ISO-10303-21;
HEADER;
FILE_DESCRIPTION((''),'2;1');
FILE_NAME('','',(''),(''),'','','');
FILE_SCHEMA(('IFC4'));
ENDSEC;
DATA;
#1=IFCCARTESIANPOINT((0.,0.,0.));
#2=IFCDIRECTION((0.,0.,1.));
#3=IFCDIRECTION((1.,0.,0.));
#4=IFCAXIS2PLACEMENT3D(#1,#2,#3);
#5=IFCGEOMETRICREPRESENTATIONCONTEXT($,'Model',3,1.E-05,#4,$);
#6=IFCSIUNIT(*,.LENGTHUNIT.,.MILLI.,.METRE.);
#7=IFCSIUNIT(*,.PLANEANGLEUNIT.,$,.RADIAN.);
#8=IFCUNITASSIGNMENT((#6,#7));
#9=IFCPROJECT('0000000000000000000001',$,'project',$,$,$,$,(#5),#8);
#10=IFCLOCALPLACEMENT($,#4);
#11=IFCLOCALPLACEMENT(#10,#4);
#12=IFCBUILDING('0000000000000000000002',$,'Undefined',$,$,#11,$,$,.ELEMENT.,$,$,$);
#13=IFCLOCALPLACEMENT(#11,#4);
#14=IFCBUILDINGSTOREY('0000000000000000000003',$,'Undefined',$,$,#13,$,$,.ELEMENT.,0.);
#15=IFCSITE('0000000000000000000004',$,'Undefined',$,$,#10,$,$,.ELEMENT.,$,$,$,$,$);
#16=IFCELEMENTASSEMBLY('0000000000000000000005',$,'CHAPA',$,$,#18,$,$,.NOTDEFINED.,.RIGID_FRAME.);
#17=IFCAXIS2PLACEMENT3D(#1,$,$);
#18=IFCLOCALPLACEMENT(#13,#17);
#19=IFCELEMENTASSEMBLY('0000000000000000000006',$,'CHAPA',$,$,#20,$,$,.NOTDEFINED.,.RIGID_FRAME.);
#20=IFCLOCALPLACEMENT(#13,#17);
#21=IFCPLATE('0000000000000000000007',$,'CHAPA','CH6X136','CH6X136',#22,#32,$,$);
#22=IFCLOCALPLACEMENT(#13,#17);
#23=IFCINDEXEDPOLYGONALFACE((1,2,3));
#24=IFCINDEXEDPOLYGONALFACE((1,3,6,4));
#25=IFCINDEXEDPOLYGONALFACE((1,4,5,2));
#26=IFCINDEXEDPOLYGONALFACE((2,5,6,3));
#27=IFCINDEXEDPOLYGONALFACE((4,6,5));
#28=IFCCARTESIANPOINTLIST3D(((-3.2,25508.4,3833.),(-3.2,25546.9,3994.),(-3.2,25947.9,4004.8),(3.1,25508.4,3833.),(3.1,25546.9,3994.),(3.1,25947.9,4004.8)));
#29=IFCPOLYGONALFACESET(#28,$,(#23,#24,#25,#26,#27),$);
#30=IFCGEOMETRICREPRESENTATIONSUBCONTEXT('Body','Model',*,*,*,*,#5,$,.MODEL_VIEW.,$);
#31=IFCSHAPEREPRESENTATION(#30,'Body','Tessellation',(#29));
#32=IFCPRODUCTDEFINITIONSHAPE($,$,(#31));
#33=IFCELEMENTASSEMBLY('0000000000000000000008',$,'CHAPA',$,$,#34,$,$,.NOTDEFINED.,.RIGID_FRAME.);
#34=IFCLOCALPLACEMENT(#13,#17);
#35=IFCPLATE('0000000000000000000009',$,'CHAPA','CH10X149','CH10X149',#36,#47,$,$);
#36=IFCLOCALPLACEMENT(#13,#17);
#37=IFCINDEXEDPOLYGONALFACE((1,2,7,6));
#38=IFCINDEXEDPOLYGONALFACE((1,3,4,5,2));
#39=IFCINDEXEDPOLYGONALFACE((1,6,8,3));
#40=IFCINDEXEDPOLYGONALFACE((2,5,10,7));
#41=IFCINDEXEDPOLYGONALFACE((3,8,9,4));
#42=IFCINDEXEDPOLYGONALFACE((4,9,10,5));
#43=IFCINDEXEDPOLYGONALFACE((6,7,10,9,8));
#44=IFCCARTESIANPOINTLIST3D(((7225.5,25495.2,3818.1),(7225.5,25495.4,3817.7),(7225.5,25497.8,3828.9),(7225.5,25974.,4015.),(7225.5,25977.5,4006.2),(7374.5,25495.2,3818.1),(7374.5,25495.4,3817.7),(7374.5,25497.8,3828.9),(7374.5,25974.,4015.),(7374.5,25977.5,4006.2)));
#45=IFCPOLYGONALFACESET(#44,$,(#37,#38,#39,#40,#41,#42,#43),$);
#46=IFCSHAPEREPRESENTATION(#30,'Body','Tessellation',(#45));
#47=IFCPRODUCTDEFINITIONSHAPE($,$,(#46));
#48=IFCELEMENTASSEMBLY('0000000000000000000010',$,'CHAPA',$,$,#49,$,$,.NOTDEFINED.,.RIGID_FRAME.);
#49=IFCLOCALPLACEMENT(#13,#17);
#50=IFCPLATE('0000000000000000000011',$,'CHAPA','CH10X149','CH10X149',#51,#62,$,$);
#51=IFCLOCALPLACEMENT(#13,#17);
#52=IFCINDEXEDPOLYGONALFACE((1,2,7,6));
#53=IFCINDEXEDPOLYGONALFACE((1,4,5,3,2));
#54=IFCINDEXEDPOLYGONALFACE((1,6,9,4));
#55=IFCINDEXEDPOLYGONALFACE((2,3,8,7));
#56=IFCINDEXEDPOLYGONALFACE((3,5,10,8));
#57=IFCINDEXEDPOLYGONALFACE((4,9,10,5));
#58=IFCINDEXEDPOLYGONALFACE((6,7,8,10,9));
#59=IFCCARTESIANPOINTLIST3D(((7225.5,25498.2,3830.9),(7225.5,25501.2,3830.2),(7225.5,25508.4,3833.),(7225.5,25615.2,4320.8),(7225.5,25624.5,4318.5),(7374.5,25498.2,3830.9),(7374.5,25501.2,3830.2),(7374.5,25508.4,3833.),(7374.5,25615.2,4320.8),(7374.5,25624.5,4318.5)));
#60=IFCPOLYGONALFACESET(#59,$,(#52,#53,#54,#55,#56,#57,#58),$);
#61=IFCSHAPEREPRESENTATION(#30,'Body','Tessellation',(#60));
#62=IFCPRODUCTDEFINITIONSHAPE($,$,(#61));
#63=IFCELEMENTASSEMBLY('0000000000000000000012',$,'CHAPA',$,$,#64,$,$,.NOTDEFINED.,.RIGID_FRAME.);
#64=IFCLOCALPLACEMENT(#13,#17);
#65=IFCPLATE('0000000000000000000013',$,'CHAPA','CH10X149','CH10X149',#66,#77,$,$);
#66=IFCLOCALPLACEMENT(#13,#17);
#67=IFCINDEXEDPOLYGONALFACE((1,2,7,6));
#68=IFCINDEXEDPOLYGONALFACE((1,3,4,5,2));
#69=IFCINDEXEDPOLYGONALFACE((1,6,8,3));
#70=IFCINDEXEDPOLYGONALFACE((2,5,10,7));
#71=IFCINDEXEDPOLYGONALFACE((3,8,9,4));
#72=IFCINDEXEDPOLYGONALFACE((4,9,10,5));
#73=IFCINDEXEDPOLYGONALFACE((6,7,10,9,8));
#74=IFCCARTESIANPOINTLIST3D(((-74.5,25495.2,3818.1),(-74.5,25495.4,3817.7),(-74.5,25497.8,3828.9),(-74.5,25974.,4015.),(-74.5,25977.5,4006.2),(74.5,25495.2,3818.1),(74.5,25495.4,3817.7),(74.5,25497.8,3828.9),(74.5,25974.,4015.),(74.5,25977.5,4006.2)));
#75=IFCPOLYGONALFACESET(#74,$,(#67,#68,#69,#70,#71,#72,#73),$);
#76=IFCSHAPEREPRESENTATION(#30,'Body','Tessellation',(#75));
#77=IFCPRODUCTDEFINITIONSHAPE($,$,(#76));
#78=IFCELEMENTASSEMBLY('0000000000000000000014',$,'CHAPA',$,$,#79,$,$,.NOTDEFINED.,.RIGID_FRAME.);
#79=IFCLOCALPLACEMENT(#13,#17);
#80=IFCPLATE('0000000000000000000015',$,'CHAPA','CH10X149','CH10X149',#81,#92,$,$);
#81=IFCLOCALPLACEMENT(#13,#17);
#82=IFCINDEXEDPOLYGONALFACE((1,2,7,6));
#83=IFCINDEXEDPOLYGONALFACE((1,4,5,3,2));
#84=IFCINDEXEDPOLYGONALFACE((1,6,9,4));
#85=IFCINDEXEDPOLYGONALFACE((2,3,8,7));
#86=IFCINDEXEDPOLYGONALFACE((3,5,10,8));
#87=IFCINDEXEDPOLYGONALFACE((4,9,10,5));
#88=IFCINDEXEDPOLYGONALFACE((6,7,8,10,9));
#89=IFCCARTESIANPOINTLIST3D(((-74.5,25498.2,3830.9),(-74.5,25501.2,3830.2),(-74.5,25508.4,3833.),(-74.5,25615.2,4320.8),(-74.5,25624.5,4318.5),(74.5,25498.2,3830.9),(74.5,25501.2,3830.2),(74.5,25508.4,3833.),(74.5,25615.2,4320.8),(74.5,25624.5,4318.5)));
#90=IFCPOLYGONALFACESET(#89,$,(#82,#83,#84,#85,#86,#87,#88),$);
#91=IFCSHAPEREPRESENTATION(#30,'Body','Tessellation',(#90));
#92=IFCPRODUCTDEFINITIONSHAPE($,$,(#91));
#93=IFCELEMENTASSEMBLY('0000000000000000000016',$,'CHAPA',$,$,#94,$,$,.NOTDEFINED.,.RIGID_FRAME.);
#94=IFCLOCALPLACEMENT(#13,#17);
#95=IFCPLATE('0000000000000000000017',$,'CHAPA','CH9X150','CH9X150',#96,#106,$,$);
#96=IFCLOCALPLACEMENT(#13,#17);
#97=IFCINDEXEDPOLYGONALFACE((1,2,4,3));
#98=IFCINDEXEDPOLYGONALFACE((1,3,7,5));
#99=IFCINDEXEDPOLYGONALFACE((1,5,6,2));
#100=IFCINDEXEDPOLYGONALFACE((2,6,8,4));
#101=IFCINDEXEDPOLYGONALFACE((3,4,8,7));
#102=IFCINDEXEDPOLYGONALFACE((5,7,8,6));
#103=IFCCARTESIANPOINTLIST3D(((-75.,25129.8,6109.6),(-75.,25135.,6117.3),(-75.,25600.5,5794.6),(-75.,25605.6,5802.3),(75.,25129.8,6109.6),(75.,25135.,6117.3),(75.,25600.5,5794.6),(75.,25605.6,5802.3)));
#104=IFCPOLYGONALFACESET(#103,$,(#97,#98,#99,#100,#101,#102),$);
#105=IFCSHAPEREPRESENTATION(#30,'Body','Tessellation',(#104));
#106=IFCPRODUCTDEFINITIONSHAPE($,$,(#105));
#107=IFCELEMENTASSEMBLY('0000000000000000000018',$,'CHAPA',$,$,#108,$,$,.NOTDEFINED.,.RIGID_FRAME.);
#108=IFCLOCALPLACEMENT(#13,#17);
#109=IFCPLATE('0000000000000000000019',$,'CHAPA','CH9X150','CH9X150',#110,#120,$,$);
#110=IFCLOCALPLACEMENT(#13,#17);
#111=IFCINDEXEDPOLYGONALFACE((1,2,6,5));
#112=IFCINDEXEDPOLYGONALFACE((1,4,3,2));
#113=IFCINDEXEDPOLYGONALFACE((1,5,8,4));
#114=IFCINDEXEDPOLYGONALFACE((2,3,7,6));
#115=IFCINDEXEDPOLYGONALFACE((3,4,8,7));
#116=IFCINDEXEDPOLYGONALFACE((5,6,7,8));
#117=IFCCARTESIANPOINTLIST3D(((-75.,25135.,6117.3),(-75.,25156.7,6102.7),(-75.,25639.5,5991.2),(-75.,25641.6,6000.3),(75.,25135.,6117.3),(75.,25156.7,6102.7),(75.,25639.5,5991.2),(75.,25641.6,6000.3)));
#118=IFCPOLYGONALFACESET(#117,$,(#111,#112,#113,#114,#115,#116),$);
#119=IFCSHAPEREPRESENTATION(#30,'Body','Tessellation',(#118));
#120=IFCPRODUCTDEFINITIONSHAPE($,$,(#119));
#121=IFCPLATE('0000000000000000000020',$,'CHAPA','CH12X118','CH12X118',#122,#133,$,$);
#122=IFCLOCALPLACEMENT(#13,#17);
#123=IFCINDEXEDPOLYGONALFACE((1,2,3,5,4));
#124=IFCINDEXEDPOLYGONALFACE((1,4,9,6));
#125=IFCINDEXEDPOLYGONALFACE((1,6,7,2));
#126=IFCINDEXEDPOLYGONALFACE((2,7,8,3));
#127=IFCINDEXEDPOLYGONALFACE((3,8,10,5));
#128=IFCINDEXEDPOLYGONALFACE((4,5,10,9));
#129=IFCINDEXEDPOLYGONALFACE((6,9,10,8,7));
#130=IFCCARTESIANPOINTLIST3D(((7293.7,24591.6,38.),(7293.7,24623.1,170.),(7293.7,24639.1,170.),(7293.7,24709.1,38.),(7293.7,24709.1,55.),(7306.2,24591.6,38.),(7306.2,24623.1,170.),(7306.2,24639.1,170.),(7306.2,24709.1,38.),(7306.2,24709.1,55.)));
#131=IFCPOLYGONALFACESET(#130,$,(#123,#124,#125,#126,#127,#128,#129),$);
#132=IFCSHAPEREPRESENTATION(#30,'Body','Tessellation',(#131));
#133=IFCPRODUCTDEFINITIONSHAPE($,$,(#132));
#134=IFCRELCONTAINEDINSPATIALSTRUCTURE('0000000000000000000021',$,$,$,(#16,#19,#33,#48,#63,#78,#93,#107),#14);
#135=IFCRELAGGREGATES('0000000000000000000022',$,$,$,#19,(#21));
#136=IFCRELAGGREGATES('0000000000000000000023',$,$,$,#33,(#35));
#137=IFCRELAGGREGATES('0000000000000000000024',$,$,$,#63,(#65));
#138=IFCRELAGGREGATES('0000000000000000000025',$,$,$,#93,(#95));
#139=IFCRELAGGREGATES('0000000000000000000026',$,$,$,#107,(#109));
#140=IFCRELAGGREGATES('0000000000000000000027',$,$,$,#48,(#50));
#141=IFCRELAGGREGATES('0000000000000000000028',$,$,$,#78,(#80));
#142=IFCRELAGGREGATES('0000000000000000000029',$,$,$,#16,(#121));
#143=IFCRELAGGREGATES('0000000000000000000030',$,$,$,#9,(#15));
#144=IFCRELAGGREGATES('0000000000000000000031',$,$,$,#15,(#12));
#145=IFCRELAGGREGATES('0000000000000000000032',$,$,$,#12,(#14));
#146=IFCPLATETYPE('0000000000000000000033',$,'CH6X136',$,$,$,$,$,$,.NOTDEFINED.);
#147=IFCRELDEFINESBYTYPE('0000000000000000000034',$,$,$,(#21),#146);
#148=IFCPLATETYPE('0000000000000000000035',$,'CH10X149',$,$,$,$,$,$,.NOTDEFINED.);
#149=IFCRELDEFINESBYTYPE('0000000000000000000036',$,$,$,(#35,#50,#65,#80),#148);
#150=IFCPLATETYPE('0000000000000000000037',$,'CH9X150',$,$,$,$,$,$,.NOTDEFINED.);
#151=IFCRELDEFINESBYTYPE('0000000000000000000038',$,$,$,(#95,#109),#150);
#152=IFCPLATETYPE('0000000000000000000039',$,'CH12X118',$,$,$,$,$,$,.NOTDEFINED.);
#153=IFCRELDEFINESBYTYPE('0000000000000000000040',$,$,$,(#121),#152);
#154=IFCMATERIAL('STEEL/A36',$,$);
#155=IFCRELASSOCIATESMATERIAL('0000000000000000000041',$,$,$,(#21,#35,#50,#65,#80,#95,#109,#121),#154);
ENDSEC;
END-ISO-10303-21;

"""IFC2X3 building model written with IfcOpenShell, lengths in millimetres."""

from ifc_helpers import new_model, si_unit, frame, origin_with_axes, place, context, subcontext, project, spatial, polyline, outline, extrude, clip, halfspace, material, type_object, element, aggregate, save


model = new_model("IFC2X3")

# Units and contexts
model_context = context("Model", 3, precision=1e-05, world=origin_with_axes())
body_context = subcontext(model_context, "Body", "Model", "MODEL_VIEW")
ifc_project = project(units=[si_unit("LENGTHUNIT", "METRE", prefix="MILLI"), si_unit("PLANEANGLEUNIT", "RADIAN")], contexts=[model_context])

# Site, building, storey
site_placement = place(None, origin_with_axes())
site = spatial("IfcSite", under=ifc_project, at=site_placement, Name="Undefined", CompositionType="ELEMENT")
building_placement = place(site_placement, origin_with_axes())
building = spatial("IfcBuilding", under=site, at=building_placement, Name="Undefined", CompositionType="ELEMENT")
storey_placement = place(building_placement, origin_with_axes())
storey = spatial("IfcBuildingStorey", under=building, at=storey_placement, Name="Undefined", CompositionType="ELEMENT", Elevation=0.0)

# Element assembly
assembly_1_placement = place(storey_placement, origin_with_axes())
assembly_1 = element("IfcElementAssembly", 1, at=assembly_1_placement, inside=storey, Name="CHAPA", AssemblyPlace="NOTDEFINED", PredefinedType="RIGID_FRAME")
ifc_material_1 = material(Name="STEEL/A36")

# Element assemblies, plates
plate_type_1 = type_object("IfcPlateType", Name="CH6X136", PredefinedType="NOTDEFINED")
assembly_2_placement = place(storey_placement, origin_with_axes())
assembly_2 = element("IfcElementAssembly", 2, at=assembly_2_placement, inside=storey, Name="CHAPA", AssemblyPlace="NOTDEFINED", PredefinedType="RIGID_FRAME")
plate_1_placement = place(assembly_2_placement, frame((0.0, 25546.9, 3994.0), z_axis=(-1.0, 0.0, 0.0), x_axis=(0.0, 0.999636, 0.026972)))
plate_1 = element("IfcPlate", 3, at=plate_1_placement, type_object=plate_type_1, material=ifc_material_1, Name="CHAPA", Description="CH6X136", ObjectType="CH6X136", context=body_context, shape_type="SweptSolid", body=[
    extrude(outline(polyline([(0.0, 0.0), (401.1, 0.0), (-42.8, 159.9), (0.0, 0.0)])), frame((0.0, 0.0, -3.1), z_axis=(0.0, 0.0, 1.0), x_axis=(1.0, 0.0, 0.0)), (0.0, 0.0, 1.0), 6.3),
])
aggregate(assembly_2, [plate_1])
assembly_3_placement = place(storey_placement, origin_with_axes())
assembly_3 = element("IfcElementAssembly", 4, at=assembly_3_placement, inside=storey, Name="CHAPA", AssemblyPlace="NOTDEFINED", PredefinedType="RIGID_FRAME")
plate_type_2 = type_object("IfcPlateType", Name="CH10X149", PredefinedType="NOTDEFINED")
plate_2_placement = place(assembly_3_placement, frame((7225.5, 25975.7, 4010.6), z_axis=(0.0, 0.364063, -0.931374), x_axis=(1.0, 0.0, 0.0)))
plate_2 = element("IfcPlate", 5, at=plate_2_placement, type_object=plate_type_2, material=ifc_material_1, Name="CHAPA", Description="CH10X149", ObjectType="CH10X149", context=body_context, shape_type="Clipping", body=[
    clip(extrude(outline(polyline([(0.0, 0.0), (149.0, 0.0), (149.0, 517.6), (0.0, 517.6), (0.0, 0.0)])), frame((0.0, 0.0, -4.8), z_axis=(0.0, 0.0, 1.0), x_axis=(1.0, 0.0, 0.0)), (0.0, 0.0, 1.0), 9.5), halfspace(frame((149.0, 517.9, 4.7), z_axis=(0.0, 0.821204, -0.570634), x_axis=(-1.0, 0.0, 0.0)), False)),
])
aggregate(assembly_3, [plate_2])
assembly_4_placement = place(storey_placement, origin_with_axes())
assembly_4 = element("IfcElementAssembly", 6, at=assembly_4_placement, inside=storey, Name="CHAPA", AssemblyPlace="NOTDEFINED", PredefinedType="RIGID_FRAME")
plate_3_placement = place(assembly_4_placement, frame((7225.5, 25619.9, 4319.6), z_axis=(0.0, 0.972612, -0.232434), x_axis=(1.0, 0.000007, 0.000031)))
plate_3 = element("IfcPlate", 7, at=plate_3_placement, type_object=plate_type_2, material=ifc_material_1, Name="CHAPA", Description="CH10X149", ObjectType="CH10X149", context=body_context, shape_type="Clipping", body=[
    clip(extrude(outline(polyline([(0.0, 0.0), (70.9, 0.0), (149.0, 0.0), (149.0, 503.6), (0.0, 503.6), (0.0, 0.0)])), frame((0.0, 0.0, -4.8), z_axis=(0.0, 0.0, 1.0), x_axis=(1.0, 0.0, 0.0)), (0.0, 0.0, 1.0), 9.5), halfspace(frame((70.9, 499.2, 4.7), z_axis=(-0.000026, 0.821245, 0.570575), x_axis=(-1.0, -0.000032, 0.0)), False)),
])
assembly_5_placement = place(storey_placement, origin_with_axes())
assembly_5 = element("IfcElementAssembly", 8, at=assembly_5_placement, inside=storey, Name="CHAPA", AssemblyPlace="NOTDEFINED", PredefinedType="RIGID_FRAME")
plate_4_placement = place(assembly_5_placement, frame((-74.5, 25975.7, 4010.6), z_axis=(0.0, 0.364063, -0.931374), x_axis=(1.0, 0.0, 0.0)))
plate_4 = element("IfcPlate", 9, at=plate_4_placement, type_object=plate_type_2, material=ifc_material_1, Name="CHAPA", Description="CH10X149", ObjectType="CH10X149", context=body_context, shape_type="Clipping", body=[
    clip(extrude(outline(polyline([(0.0, 0.0), (149.0, 0.0), (149.0, 517.6), (0.0, 517.6), (0.0, 0.0)])), frame((0.0, 0.0, -4.8), z_axis=(0.0, 0.0, 1.0), x_axis=(1.0, 0.0, 0.0)), (0.0, 0.0, 1.0), 9.5), halfspace(frame((149.0, 517.9, 4.7), z_axis=(0.0, 0.821204, -0.570634), x_axis=(-1.0, 0.0, 0.0)), False)),
])
aggregate(assembly_5, [plate_4])
assembly_6_placement = place(storey_placement, origin_with_axes())
assembly_6 = element("IfcElementAssembly", 10, at=assembly_6_placement, inside=storey, Name="CHAPA", AssemblyPlace="NOTDEFINED", PredefinedType="RIGID_FRAME")
plate_5_placement = place(assembly_6_placement, frame((-74.5, 25619.9, 4319.6), z_axis=(0.0, 0.972612, -0.232434), x_axis=(1.0, 0.000007, 0.000031)))
plate_5 = element("IfcPlate", 11, at=plate_5_placement, type_object=plate_type_2, material=ifc_material_1, Name="CHAPA", Description="CH10X149", ObjectType="CH10X149", context=body_context, shape_type="Clipping", body=[
    clip(extrude(outline(polyline([(0.0, 0.0), (70.9, 0.0), (149.0, 0.0), (149.0, 503.6), (0.0, 503.6), (0.0, 0.0)])), frame((0.0, 0.0, -4.8), z_axis=(0.0, 0.0, 1.0), x_axis=(1.0, 0.0, 0.0)), (0.0, 0.0, 1.0), 9.5), halfspace(frame((70.9, 499.2, 4.7), z_axis=(-0.000026, 0.821245, 0.570575), x_axis=(-1.0, -0.000032, 0.0)), False)),
])
assembly_7_placement = place(storey_placement, origin_with_axes())
assembly_7 = element("IfcElementAssembly", 12, at=assembly_7_placement, inside=storey, Name="CHAPA", AssemblyPlace="NOTDEFINED", PredefinedType="RIGID_FRAME")
plate_type_3 = type_object("IfcPlateType", Name="CH9X150", PredefinedType="NOTDEFINED")
plate_6_placement = place(assembly_7_placement, frame((75.0, 25132.4, 6113.5), z_axis=(0.0, -0.55615, -0.831082), x_axis=(-1.0, 0.0, 0.0)))
plate_6 = element("IfcPlate", 13, at=plate_6_placement, type_object=plate_type_3, material=ifc_material_1, Name="CHAPA", Description="CH9X150", ObjectType="CH9X150", context=body_context, shape_type="SweptSolid", body=[
    extrude(outline(polyline([(0.0, 0.0), (150.0, 0.0), (150.0, 566.3), (0.0, 566.3), (0.0, 0.0)])), frame((0.0, 0.0, -4.7), z_axis=(0.0, 0.0, 1.0), x_axis=(1.0, 0.0, 0.0)), (0.0, 0.0, 1.0), 9.3),
])
aggregate(assembly_7, [plate_6])
assembly_8_placement = place(storey_placement, origin_with_axes())
assembly_8 = element("IfcElementAssembly", 14, at=assembly_8_placement, inside=storey, Name="CHAPA", AssemblyPlace="NOTDEFINED", PredefinedType="RIGID_FRAME")
plate_7_placement = place(assembly_8_placement, frame((75.0, 25640.6, 5995.7), z_axis=(0.0, -0.225124, -0.97433), x_axis=(0.0, -0.97433, 0.225124)))
plate_7 = element("IfcPlate", 15, at=plate_7_placement, type_object=plate_type_3, material=ifc_material_1, Name="CHAPA", Description="CH9X150", ObjectType="CH9X150", context=body_context, shape_type="Clipping", body=[
    clip(extrude(outline(polyline([(0.0, 0.0), (520.0, 0.0), (520.0, 150.0), (0.0, 150.0), (0.0, 0.0)])), frame((0.0, 0.0, -4.7), z_axis=(0.0, 0.0, 1.0), x_axis=(1.0, 0.0, 0.0)), (0.0, 0.0, 1.0), 9.3), halfspace(frame((520.0, -500.0, -4.7), z_axis=(0.354778, 0.0, 0.934951), x_axis=(-0.934951, 0.0, 0.354778)), False)),
])
aggregate(assembly_8, [plate_7])

# Plate
plate_type_4 = type_object("IfcPlateType", Name="CH12X118", PredefinedType="NOTDEFINED")
plate_8_placement = place(assembly_1_placement, frame((7300.0, 24709.1, 38.0), z_axis=(-1.0, 0.0, 0.0), x_axis=(0.0, -1.0, 0.0)))
plate_8 = element("IfcPlate", 16, at=plate_8_placement, type_object=plate_type_4, material=ifc_material_1, Name="CHAPA", Description="CH12X118", ObjectType="CH12X118", context=body_context, shape_type="SweptSolid", body=[
    extrude(outline(polyline([(0.0, 0.0), (117.5, 0.0), (85.9, 132.0), (70.0, 132.0), (0.0, 17.0), (0.0, 0.0)])), frame((0.0, 0.0, -6.2), z_axis=(0.0, 0.0, 1.0), x_axis=(1.0, 0.0, 0.0)), (0.0, 0.0, 1.0), 12.5),
])

aggregate(assembly_4, [plate_3])
aggregate(assembly_6, [plate_5])

aggregate(assembly_1, [plate_8])

save(model, "model.ifc")
